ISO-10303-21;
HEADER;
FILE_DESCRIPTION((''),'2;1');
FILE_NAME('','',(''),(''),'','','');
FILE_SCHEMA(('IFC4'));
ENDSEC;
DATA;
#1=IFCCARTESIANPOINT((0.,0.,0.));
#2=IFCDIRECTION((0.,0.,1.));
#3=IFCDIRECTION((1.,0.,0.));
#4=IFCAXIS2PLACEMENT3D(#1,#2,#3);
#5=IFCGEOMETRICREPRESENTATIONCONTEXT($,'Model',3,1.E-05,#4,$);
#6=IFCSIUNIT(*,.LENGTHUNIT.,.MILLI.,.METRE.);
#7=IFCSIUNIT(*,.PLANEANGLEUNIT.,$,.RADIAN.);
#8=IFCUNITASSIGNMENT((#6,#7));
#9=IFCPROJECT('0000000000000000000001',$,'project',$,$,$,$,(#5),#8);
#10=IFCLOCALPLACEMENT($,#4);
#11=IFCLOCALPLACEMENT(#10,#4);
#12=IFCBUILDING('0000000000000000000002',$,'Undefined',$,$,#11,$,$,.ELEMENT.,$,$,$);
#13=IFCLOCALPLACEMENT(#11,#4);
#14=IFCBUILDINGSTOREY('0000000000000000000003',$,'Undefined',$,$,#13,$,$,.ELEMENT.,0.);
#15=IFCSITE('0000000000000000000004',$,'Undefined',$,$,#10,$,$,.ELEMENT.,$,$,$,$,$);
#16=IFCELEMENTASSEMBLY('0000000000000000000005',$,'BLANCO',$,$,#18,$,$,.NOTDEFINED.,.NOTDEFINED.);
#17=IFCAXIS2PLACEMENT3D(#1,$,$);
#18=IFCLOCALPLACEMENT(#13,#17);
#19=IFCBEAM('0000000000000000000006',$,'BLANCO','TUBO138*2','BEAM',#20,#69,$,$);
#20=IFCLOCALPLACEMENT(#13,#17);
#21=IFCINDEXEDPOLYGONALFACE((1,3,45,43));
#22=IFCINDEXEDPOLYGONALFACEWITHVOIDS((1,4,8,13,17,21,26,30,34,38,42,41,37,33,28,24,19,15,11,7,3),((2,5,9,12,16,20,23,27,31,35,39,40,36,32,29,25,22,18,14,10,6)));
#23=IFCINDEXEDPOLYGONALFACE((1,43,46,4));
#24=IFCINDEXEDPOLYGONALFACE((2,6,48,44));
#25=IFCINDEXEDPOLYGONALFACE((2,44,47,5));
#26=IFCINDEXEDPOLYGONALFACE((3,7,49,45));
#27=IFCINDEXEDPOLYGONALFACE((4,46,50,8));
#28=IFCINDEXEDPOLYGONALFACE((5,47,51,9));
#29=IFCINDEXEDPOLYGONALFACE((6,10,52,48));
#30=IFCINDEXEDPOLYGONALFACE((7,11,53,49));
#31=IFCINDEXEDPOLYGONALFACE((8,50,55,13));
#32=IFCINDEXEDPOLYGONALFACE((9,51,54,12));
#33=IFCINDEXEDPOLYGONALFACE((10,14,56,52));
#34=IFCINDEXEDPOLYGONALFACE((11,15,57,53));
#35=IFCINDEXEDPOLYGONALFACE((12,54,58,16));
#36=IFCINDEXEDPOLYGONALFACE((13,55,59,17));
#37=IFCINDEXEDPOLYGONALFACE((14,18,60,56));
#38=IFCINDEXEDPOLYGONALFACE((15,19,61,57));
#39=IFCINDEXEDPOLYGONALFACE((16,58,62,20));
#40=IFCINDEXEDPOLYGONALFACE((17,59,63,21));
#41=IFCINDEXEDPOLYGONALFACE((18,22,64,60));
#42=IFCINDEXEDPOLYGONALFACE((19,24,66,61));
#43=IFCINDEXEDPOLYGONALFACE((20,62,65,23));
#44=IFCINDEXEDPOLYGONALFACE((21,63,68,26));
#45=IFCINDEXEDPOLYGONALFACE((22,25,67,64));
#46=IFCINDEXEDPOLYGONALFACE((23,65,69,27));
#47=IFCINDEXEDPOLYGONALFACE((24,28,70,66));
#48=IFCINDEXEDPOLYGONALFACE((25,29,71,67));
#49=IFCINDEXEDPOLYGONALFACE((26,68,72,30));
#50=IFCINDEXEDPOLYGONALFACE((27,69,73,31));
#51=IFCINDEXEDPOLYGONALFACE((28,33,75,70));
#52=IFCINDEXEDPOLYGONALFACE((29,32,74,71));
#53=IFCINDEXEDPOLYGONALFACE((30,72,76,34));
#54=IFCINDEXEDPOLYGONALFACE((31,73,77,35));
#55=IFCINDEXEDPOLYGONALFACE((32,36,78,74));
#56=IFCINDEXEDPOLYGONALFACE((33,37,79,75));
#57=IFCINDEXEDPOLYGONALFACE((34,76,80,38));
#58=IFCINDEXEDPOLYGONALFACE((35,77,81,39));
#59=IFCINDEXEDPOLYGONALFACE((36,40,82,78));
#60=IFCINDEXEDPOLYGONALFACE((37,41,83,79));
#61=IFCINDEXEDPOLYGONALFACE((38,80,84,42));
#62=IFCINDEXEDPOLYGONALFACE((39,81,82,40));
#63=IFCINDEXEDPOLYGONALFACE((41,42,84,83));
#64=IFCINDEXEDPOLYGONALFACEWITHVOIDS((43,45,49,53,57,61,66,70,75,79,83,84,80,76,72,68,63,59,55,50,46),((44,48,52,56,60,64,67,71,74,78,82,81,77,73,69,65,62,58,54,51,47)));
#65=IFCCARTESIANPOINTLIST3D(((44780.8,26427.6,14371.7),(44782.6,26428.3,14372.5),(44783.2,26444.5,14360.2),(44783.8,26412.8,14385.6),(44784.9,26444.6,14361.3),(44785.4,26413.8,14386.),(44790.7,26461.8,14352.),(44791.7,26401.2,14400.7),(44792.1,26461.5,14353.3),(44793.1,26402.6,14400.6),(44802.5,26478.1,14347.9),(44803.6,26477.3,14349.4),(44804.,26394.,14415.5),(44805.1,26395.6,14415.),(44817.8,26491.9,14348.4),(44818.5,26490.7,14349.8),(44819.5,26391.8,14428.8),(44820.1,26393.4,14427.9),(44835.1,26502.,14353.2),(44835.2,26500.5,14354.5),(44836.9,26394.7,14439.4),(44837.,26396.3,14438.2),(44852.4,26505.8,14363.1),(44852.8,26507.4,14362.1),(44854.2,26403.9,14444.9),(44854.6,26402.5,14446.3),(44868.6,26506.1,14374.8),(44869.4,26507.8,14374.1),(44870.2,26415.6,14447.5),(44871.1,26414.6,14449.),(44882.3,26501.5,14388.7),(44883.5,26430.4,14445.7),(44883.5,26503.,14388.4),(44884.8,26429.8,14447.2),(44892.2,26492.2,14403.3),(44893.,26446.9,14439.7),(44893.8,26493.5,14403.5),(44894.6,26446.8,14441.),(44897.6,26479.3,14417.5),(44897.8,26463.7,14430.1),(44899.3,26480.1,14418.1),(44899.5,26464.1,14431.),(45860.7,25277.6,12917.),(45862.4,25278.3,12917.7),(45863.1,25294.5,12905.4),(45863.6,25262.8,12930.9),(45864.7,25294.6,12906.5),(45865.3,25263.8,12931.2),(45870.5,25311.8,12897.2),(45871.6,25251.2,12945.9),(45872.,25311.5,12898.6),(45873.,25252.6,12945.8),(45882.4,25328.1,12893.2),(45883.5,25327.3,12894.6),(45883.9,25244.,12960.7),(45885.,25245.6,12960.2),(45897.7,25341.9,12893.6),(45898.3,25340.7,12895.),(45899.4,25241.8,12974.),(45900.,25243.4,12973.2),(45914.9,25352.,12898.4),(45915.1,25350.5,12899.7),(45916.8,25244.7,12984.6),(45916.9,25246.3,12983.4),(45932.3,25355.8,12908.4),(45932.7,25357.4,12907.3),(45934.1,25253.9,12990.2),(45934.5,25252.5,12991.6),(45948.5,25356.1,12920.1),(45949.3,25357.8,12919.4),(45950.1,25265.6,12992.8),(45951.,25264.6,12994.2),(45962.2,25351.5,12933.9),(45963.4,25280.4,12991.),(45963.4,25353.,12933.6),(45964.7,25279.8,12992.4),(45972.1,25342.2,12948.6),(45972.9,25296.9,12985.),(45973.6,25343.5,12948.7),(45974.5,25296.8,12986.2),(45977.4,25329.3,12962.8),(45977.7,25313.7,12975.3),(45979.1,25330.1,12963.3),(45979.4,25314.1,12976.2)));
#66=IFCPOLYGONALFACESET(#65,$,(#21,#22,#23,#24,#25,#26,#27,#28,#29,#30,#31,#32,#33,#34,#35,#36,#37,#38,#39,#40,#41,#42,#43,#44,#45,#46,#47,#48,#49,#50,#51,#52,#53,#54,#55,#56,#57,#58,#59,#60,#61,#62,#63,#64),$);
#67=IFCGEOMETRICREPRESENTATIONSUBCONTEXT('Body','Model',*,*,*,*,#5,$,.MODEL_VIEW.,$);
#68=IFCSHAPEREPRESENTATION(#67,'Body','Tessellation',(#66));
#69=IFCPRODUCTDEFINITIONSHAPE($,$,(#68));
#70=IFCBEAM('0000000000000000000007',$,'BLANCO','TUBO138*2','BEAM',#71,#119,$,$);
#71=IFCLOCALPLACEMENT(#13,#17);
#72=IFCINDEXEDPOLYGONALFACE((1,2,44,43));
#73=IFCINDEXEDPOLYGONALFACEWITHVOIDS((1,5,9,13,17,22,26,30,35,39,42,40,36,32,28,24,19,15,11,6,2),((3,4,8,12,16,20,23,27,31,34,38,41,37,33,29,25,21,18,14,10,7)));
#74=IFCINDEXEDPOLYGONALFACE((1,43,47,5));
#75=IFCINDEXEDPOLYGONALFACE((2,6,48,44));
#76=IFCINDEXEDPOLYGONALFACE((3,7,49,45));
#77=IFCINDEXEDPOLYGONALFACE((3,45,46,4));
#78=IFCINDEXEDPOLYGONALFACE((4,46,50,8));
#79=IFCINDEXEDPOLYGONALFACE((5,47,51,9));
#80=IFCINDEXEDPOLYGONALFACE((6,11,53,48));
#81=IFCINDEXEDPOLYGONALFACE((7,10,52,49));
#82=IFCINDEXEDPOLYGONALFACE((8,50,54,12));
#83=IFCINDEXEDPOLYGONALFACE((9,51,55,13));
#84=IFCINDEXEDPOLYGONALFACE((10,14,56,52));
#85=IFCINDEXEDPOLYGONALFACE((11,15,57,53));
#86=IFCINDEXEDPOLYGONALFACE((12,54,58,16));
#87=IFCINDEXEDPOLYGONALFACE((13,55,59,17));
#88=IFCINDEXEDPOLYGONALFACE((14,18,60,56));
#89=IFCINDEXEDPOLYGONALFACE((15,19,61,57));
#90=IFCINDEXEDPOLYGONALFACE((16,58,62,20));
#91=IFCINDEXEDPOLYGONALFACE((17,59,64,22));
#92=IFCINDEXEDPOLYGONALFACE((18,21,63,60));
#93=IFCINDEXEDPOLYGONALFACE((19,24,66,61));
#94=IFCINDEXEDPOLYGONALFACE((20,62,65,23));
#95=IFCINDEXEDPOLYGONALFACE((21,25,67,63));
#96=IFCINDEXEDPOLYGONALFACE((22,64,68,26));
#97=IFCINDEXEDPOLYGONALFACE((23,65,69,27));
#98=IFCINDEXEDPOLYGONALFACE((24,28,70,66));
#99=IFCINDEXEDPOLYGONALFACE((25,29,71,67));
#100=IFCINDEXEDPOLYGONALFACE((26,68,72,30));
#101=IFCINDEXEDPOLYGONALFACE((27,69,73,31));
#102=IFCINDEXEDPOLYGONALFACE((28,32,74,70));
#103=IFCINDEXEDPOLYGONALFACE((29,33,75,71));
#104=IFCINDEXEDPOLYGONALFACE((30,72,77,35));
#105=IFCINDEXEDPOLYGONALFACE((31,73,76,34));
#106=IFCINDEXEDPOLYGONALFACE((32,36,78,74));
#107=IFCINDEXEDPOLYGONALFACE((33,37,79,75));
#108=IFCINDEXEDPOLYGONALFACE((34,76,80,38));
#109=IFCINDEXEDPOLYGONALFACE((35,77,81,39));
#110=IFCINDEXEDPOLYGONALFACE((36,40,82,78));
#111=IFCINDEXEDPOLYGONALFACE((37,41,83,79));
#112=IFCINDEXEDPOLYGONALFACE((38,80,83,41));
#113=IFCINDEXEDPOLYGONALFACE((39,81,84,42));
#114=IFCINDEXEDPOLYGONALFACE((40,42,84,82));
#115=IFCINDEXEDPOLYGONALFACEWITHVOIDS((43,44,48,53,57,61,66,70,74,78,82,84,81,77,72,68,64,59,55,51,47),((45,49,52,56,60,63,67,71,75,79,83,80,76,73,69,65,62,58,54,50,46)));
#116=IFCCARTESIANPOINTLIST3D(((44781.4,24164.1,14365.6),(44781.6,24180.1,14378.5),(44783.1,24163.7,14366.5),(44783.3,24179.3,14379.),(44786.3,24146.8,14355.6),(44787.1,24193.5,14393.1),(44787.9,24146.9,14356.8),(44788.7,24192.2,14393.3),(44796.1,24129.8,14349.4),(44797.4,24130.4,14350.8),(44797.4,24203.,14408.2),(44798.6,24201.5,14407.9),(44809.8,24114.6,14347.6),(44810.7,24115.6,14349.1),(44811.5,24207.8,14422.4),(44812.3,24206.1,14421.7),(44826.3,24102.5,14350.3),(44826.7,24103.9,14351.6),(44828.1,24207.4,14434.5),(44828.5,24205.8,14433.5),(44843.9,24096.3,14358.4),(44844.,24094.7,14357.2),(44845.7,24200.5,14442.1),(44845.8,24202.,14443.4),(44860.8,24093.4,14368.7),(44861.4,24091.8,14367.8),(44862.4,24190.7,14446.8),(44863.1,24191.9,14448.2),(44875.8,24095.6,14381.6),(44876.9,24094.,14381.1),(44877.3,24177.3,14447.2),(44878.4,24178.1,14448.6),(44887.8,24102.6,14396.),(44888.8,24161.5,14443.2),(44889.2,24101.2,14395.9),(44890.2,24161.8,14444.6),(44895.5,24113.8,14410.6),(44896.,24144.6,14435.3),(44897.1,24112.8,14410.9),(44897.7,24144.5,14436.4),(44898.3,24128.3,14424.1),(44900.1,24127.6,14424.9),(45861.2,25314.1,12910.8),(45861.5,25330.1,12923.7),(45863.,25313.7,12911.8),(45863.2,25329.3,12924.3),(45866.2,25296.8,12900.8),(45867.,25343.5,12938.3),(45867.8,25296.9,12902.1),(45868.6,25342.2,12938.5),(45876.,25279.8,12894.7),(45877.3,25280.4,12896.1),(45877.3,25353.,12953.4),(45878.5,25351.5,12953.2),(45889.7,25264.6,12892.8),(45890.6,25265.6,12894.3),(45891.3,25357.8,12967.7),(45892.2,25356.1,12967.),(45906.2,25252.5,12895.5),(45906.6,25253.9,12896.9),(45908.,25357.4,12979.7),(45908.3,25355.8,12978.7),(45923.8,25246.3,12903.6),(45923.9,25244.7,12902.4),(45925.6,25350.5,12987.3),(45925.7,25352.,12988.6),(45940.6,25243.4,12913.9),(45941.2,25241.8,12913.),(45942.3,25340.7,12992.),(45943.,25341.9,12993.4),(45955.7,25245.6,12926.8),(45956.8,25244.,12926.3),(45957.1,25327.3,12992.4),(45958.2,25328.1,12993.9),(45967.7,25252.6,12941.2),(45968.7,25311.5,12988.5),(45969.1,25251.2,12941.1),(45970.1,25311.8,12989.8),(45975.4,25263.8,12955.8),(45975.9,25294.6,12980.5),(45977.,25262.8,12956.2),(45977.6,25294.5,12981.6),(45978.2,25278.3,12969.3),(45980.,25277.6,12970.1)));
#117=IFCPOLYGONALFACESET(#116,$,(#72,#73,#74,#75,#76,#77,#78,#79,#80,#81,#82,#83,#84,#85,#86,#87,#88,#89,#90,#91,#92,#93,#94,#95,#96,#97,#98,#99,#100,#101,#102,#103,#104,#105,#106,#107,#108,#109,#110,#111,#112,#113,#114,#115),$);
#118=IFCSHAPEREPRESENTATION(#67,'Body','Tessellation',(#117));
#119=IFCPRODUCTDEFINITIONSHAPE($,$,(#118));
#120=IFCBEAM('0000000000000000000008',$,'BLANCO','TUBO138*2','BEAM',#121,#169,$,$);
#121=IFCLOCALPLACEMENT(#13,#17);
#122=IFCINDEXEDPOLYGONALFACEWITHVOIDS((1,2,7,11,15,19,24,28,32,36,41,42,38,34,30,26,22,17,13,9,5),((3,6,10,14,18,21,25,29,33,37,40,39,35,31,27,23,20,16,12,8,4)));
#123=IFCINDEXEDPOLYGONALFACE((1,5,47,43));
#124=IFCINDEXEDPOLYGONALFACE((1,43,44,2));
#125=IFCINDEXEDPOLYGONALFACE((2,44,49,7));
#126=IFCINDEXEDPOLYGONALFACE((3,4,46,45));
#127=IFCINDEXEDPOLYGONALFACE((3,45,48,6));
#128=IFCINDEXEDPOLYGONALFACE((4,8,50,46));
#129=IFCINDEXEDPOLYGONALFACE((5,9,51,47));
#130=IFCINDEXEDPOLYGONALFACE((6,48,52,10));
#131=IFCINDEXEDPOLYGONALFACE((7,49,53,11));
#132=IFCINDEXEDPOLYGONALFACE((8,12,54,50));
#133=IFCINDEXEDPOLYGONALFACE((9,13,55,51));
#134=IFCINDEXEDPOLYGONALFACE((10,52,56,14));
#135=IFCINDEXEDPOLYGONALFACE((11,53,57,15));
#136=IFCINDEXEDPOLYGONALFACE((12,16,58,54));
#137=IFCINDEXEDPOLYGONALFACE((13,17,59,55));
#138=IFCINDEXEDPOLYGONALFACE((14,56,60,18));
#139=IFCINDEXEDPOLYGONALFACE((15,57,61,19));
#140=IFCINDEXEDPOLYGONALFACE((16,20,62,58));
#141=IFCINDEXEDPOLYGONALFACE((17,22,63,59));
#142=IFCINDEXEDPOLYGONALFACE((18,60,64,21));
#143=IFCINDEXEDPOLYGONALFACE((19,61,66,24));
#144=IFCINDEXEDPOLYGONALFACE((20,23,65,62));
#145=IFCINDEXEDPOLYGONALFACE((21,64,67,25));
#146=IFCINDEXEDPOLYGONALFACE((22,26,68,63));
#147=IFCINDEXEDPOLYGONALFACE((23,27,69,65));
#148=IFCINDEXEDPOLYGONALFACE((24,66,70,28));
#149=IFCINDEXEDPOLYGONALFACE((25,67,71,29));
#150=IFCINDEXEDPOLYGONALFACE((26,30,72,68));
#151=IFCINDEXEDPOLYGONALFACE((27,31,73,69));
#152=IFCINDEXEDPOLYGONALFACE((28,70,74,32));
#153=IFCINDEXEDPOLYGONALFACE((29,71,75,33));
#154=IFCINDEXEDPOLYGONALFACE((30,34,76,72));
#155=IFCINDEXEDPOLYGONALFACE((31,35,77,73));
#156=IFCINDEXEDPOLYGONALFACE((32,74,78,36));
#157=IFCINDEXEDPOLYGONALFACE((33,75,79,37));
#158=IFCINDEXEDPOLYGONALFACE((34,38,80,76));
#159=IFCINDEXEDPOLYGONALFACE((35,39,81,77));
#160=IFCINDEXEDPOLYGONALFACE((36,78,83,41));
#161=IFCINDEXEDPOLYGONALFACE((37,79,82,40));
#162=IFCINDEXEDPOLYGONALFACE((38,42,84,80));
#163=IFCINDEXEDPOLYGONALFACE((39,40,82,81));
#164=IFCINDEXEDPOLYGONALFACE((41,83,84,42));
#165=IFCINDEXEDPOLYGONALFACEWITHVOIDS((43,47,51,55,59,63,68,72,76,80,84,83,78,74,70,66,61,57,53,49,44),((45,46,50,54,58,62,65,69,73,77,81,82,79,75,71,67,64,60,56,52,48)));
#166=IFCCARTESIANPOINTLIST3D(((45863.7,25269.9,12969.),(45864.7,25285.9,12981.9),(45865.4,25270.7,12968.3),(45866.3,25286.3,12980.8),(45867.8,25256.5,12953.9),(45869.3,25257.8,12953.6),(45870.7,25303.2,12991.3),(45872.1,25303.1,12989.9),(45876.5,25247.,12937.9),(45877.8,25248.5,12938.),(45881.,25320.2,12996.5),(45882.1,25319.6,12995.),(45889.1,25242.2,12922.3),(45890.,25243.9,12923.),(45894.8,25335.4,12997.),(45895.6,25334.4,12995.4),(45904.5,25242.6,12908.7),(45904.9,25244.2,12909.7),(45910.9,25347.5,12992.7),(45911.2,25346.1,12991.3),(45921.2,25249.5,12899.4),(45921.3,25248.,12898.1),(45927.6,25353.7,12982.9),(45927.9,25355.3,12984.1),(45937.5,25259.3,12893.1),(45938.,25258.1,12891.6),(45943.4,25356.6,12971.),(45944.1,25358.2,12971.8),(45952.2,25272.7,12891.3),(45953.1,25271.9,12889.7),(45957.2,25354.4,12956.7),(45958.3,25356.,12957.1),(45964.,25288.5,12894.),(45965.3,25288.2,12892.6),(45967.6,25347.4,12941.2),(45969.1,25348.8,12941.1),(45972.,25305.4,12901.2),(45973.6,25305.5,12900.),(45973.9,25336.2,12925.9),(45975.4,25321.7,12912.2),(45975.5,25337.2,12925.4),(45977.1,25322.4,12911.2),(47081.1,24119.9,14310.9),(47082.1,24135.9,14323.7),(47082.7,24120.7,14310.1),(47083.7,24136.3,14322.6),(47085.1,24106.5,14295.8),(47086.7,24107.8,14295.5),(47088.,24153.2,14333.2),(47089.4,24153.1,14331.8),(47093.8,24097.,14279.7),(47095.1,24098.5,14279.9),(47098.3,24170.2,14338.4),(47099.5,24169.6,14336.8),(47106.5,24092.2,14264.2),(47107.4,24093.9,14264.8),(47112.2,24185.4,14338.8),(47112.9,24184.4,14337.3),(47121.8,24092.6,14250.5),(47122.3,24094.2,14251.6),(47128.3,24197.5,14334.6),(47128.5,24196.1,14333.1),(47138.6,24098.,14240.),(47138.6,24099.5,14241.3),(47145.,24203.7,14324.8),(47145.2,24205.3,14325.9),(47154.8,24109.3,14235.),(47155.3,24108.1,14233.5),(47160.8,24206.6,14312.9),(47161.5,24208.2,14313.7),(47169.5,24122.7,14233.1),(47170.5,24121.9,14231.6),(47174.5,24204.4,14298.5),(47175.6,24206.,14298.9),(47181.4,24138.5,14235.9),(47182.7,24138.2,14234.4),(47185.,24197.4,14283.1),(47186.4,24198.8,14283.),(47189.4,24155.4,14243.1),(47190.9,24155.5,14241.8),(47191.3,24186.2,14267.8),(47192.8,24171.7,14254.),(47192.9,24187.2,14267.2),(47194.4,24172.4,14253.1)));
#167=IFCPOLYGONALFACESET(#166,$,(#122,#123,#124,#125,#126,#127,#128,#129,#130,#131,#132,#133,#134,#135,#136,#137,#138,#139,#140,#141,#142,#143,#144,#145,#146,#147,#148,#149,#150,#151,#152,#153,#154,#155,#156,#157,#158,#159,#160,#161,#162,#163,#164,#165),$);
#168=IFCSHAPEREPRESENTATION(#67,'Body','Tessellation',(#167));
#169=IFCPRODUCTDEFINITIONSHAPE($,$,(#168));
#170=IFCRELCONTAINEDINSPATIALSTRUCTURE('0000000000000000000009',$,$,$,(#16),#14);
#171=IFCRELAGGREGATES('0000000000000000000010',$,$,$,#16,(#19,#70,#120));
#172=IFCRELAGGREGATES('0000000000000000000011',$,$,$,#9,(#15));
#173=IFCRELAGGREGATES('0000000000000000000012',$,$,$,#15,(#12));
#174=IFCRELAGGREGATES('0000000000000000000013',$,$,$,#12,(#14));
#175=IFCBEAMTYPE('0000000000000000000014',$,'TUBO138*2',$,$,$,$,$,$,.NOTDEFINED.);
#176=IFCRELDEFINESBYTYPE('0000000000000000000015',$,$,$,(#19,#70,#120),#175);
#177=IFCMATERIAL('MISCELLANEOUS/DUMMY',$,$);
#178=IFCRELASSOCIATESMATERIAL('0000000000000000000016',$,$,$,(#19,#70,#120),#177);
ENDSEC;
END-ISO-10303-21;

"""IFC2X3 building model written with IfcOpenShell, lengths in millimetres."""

from ifc_helpers import new_model, si_unit, frame, origin_with_axes, origin_2d_with_axis, place, context, subcontext, project, spatial, hollow_circle, extrude, material, type_object, element, aggregate, save


model = new_model("IFC2X3")

# Units and contexts
model_context = context("Model", 3, precision=1e-05, world=origin_with_axes())
body_context = subcontext(model_context, "Body", "Model", "MODEL_VIEW")
ifc_project = project(units=[si_unit("LENGTHUNIT", "METRE", prefix="MILLI"), si_unit("PLANEANGLEUNIT", "RADIAN")], contexts=[model_context])

# Site, building, storey
site_placement = place(None, origin_with_axes())
site = spatial("IfcSite", under=ifc_project, at=site_placement, Name="Undefined", CompositionType="ELEMENT")
building_placement = place(site_placement, origin_with_axes())
building = spatial("IfcBuilding", under=site, at=building_placement, Name="Undefined", CompositionType="ELEMENT")
storey_placement = place(building_placement, origin_with_axes())
storey = spatial("IfcBuildingStorey", under=building, at=storey_placement, Name="Undefined", CompositionType="ELEMENT", Elevation=0.0)

# Element assembly, beams
assembly_placement = place(storey_placement, origin_with_axes())
assembly = element("IfcElementAssembly", 1, at=assembly_placement, inside=storey, Name="BLANCO", AssemblyPlace="NOTDEFINED", PredefinedType="NOTDEFINED")
ifc_material = material(Name="MISCELLANEOUS/DUMMY")
beam_type = type_object("IfcBeamType", Name="TUBO138*2", PredefinedType="NOTDEFINED")
beam_1_placement = place(assembly_placement, frame((45920.3, 25300.0, 12943.5), z_axis=(-0.497966, 0.461316, -0.734314), x_axis=(-0.503224, 0.535899, 0.677922)))
beam_1 = element("IfcBeam", 2, at=beam_1_placement, type_object=beam_type, material=ifc_material, Name="BLANCO", Description="TUBO138*2", ObjectType="BEAM", context=body_context, shape_type="SweptSolid", body=[
    extrude(hollow_circle(Radius=69.0, WallThickness=2.0, at=origin_2d_with_axis()), frame((2145.9, 0.0, 0.0), z_axis=(-1.0, 0.0, 0.0), x_axis=(0.0, -1.0, 0.0)), (0.0, 0.0, 1.0), 2145.9),
])
beam_2_placement = place(assembly_placement, frame((45920.3, 25300.0, 12943.5), z_axis=(-0.497966, -0.461316, -0.734314), x_axis=(-0.503224, -0.535899, 0.677922)))
beam_2 = element("IfcBeam", 3, at=beam_2_placement, type_object=beam_type, material=ifc_material, Name="BLANCO", Description="TUBO138*2", ObjectType="BEAM", context=body_context, shape_type="SweptSolid", body=[
    extrude(hollow_circle(Radius=69.0, WallThickness=2.0, at=origin_2d_with_axis()), frame((2145.9, 0.0, 0.0), z_axis=(-1.0, 0.0, 0.0), x_axis=(0.0, -1.0, 0.0)), (0.0, 0.0, 1.0), 2145.9),
])
beam_3_placement = place(assembly_placement, frame((45920.3, 25300.0, 12943.5), z_axis=(0.423552, -0.461316, -0.77961), x_axis=(0.567282, -0.535899, 0.625303)))
beam_3 = element("IfcBeam", 4, at=beam_3_placement, type_object=beam_type, material=ifc_material, Name="BLANCO", Description="TUBO138*2", ObjectType="BEAM", context=body_context, shape_type="SweptSolid", body=[
    extrude(hollow_circle(Radius=69.0, WallThickness=2.0, at=origin_2d_with_axis()), frame((2145.9, 0.0, 0.0), z_axis=(-1.0, 0.0, 0.0), x_axis=(0.0, -1.0, 0.0)), (0.0, 0.0, 1.0), 2145.9),
])
aggregate(assembly, [beam_1, beam_2, beam_3])

save(model, "model.ifc")
